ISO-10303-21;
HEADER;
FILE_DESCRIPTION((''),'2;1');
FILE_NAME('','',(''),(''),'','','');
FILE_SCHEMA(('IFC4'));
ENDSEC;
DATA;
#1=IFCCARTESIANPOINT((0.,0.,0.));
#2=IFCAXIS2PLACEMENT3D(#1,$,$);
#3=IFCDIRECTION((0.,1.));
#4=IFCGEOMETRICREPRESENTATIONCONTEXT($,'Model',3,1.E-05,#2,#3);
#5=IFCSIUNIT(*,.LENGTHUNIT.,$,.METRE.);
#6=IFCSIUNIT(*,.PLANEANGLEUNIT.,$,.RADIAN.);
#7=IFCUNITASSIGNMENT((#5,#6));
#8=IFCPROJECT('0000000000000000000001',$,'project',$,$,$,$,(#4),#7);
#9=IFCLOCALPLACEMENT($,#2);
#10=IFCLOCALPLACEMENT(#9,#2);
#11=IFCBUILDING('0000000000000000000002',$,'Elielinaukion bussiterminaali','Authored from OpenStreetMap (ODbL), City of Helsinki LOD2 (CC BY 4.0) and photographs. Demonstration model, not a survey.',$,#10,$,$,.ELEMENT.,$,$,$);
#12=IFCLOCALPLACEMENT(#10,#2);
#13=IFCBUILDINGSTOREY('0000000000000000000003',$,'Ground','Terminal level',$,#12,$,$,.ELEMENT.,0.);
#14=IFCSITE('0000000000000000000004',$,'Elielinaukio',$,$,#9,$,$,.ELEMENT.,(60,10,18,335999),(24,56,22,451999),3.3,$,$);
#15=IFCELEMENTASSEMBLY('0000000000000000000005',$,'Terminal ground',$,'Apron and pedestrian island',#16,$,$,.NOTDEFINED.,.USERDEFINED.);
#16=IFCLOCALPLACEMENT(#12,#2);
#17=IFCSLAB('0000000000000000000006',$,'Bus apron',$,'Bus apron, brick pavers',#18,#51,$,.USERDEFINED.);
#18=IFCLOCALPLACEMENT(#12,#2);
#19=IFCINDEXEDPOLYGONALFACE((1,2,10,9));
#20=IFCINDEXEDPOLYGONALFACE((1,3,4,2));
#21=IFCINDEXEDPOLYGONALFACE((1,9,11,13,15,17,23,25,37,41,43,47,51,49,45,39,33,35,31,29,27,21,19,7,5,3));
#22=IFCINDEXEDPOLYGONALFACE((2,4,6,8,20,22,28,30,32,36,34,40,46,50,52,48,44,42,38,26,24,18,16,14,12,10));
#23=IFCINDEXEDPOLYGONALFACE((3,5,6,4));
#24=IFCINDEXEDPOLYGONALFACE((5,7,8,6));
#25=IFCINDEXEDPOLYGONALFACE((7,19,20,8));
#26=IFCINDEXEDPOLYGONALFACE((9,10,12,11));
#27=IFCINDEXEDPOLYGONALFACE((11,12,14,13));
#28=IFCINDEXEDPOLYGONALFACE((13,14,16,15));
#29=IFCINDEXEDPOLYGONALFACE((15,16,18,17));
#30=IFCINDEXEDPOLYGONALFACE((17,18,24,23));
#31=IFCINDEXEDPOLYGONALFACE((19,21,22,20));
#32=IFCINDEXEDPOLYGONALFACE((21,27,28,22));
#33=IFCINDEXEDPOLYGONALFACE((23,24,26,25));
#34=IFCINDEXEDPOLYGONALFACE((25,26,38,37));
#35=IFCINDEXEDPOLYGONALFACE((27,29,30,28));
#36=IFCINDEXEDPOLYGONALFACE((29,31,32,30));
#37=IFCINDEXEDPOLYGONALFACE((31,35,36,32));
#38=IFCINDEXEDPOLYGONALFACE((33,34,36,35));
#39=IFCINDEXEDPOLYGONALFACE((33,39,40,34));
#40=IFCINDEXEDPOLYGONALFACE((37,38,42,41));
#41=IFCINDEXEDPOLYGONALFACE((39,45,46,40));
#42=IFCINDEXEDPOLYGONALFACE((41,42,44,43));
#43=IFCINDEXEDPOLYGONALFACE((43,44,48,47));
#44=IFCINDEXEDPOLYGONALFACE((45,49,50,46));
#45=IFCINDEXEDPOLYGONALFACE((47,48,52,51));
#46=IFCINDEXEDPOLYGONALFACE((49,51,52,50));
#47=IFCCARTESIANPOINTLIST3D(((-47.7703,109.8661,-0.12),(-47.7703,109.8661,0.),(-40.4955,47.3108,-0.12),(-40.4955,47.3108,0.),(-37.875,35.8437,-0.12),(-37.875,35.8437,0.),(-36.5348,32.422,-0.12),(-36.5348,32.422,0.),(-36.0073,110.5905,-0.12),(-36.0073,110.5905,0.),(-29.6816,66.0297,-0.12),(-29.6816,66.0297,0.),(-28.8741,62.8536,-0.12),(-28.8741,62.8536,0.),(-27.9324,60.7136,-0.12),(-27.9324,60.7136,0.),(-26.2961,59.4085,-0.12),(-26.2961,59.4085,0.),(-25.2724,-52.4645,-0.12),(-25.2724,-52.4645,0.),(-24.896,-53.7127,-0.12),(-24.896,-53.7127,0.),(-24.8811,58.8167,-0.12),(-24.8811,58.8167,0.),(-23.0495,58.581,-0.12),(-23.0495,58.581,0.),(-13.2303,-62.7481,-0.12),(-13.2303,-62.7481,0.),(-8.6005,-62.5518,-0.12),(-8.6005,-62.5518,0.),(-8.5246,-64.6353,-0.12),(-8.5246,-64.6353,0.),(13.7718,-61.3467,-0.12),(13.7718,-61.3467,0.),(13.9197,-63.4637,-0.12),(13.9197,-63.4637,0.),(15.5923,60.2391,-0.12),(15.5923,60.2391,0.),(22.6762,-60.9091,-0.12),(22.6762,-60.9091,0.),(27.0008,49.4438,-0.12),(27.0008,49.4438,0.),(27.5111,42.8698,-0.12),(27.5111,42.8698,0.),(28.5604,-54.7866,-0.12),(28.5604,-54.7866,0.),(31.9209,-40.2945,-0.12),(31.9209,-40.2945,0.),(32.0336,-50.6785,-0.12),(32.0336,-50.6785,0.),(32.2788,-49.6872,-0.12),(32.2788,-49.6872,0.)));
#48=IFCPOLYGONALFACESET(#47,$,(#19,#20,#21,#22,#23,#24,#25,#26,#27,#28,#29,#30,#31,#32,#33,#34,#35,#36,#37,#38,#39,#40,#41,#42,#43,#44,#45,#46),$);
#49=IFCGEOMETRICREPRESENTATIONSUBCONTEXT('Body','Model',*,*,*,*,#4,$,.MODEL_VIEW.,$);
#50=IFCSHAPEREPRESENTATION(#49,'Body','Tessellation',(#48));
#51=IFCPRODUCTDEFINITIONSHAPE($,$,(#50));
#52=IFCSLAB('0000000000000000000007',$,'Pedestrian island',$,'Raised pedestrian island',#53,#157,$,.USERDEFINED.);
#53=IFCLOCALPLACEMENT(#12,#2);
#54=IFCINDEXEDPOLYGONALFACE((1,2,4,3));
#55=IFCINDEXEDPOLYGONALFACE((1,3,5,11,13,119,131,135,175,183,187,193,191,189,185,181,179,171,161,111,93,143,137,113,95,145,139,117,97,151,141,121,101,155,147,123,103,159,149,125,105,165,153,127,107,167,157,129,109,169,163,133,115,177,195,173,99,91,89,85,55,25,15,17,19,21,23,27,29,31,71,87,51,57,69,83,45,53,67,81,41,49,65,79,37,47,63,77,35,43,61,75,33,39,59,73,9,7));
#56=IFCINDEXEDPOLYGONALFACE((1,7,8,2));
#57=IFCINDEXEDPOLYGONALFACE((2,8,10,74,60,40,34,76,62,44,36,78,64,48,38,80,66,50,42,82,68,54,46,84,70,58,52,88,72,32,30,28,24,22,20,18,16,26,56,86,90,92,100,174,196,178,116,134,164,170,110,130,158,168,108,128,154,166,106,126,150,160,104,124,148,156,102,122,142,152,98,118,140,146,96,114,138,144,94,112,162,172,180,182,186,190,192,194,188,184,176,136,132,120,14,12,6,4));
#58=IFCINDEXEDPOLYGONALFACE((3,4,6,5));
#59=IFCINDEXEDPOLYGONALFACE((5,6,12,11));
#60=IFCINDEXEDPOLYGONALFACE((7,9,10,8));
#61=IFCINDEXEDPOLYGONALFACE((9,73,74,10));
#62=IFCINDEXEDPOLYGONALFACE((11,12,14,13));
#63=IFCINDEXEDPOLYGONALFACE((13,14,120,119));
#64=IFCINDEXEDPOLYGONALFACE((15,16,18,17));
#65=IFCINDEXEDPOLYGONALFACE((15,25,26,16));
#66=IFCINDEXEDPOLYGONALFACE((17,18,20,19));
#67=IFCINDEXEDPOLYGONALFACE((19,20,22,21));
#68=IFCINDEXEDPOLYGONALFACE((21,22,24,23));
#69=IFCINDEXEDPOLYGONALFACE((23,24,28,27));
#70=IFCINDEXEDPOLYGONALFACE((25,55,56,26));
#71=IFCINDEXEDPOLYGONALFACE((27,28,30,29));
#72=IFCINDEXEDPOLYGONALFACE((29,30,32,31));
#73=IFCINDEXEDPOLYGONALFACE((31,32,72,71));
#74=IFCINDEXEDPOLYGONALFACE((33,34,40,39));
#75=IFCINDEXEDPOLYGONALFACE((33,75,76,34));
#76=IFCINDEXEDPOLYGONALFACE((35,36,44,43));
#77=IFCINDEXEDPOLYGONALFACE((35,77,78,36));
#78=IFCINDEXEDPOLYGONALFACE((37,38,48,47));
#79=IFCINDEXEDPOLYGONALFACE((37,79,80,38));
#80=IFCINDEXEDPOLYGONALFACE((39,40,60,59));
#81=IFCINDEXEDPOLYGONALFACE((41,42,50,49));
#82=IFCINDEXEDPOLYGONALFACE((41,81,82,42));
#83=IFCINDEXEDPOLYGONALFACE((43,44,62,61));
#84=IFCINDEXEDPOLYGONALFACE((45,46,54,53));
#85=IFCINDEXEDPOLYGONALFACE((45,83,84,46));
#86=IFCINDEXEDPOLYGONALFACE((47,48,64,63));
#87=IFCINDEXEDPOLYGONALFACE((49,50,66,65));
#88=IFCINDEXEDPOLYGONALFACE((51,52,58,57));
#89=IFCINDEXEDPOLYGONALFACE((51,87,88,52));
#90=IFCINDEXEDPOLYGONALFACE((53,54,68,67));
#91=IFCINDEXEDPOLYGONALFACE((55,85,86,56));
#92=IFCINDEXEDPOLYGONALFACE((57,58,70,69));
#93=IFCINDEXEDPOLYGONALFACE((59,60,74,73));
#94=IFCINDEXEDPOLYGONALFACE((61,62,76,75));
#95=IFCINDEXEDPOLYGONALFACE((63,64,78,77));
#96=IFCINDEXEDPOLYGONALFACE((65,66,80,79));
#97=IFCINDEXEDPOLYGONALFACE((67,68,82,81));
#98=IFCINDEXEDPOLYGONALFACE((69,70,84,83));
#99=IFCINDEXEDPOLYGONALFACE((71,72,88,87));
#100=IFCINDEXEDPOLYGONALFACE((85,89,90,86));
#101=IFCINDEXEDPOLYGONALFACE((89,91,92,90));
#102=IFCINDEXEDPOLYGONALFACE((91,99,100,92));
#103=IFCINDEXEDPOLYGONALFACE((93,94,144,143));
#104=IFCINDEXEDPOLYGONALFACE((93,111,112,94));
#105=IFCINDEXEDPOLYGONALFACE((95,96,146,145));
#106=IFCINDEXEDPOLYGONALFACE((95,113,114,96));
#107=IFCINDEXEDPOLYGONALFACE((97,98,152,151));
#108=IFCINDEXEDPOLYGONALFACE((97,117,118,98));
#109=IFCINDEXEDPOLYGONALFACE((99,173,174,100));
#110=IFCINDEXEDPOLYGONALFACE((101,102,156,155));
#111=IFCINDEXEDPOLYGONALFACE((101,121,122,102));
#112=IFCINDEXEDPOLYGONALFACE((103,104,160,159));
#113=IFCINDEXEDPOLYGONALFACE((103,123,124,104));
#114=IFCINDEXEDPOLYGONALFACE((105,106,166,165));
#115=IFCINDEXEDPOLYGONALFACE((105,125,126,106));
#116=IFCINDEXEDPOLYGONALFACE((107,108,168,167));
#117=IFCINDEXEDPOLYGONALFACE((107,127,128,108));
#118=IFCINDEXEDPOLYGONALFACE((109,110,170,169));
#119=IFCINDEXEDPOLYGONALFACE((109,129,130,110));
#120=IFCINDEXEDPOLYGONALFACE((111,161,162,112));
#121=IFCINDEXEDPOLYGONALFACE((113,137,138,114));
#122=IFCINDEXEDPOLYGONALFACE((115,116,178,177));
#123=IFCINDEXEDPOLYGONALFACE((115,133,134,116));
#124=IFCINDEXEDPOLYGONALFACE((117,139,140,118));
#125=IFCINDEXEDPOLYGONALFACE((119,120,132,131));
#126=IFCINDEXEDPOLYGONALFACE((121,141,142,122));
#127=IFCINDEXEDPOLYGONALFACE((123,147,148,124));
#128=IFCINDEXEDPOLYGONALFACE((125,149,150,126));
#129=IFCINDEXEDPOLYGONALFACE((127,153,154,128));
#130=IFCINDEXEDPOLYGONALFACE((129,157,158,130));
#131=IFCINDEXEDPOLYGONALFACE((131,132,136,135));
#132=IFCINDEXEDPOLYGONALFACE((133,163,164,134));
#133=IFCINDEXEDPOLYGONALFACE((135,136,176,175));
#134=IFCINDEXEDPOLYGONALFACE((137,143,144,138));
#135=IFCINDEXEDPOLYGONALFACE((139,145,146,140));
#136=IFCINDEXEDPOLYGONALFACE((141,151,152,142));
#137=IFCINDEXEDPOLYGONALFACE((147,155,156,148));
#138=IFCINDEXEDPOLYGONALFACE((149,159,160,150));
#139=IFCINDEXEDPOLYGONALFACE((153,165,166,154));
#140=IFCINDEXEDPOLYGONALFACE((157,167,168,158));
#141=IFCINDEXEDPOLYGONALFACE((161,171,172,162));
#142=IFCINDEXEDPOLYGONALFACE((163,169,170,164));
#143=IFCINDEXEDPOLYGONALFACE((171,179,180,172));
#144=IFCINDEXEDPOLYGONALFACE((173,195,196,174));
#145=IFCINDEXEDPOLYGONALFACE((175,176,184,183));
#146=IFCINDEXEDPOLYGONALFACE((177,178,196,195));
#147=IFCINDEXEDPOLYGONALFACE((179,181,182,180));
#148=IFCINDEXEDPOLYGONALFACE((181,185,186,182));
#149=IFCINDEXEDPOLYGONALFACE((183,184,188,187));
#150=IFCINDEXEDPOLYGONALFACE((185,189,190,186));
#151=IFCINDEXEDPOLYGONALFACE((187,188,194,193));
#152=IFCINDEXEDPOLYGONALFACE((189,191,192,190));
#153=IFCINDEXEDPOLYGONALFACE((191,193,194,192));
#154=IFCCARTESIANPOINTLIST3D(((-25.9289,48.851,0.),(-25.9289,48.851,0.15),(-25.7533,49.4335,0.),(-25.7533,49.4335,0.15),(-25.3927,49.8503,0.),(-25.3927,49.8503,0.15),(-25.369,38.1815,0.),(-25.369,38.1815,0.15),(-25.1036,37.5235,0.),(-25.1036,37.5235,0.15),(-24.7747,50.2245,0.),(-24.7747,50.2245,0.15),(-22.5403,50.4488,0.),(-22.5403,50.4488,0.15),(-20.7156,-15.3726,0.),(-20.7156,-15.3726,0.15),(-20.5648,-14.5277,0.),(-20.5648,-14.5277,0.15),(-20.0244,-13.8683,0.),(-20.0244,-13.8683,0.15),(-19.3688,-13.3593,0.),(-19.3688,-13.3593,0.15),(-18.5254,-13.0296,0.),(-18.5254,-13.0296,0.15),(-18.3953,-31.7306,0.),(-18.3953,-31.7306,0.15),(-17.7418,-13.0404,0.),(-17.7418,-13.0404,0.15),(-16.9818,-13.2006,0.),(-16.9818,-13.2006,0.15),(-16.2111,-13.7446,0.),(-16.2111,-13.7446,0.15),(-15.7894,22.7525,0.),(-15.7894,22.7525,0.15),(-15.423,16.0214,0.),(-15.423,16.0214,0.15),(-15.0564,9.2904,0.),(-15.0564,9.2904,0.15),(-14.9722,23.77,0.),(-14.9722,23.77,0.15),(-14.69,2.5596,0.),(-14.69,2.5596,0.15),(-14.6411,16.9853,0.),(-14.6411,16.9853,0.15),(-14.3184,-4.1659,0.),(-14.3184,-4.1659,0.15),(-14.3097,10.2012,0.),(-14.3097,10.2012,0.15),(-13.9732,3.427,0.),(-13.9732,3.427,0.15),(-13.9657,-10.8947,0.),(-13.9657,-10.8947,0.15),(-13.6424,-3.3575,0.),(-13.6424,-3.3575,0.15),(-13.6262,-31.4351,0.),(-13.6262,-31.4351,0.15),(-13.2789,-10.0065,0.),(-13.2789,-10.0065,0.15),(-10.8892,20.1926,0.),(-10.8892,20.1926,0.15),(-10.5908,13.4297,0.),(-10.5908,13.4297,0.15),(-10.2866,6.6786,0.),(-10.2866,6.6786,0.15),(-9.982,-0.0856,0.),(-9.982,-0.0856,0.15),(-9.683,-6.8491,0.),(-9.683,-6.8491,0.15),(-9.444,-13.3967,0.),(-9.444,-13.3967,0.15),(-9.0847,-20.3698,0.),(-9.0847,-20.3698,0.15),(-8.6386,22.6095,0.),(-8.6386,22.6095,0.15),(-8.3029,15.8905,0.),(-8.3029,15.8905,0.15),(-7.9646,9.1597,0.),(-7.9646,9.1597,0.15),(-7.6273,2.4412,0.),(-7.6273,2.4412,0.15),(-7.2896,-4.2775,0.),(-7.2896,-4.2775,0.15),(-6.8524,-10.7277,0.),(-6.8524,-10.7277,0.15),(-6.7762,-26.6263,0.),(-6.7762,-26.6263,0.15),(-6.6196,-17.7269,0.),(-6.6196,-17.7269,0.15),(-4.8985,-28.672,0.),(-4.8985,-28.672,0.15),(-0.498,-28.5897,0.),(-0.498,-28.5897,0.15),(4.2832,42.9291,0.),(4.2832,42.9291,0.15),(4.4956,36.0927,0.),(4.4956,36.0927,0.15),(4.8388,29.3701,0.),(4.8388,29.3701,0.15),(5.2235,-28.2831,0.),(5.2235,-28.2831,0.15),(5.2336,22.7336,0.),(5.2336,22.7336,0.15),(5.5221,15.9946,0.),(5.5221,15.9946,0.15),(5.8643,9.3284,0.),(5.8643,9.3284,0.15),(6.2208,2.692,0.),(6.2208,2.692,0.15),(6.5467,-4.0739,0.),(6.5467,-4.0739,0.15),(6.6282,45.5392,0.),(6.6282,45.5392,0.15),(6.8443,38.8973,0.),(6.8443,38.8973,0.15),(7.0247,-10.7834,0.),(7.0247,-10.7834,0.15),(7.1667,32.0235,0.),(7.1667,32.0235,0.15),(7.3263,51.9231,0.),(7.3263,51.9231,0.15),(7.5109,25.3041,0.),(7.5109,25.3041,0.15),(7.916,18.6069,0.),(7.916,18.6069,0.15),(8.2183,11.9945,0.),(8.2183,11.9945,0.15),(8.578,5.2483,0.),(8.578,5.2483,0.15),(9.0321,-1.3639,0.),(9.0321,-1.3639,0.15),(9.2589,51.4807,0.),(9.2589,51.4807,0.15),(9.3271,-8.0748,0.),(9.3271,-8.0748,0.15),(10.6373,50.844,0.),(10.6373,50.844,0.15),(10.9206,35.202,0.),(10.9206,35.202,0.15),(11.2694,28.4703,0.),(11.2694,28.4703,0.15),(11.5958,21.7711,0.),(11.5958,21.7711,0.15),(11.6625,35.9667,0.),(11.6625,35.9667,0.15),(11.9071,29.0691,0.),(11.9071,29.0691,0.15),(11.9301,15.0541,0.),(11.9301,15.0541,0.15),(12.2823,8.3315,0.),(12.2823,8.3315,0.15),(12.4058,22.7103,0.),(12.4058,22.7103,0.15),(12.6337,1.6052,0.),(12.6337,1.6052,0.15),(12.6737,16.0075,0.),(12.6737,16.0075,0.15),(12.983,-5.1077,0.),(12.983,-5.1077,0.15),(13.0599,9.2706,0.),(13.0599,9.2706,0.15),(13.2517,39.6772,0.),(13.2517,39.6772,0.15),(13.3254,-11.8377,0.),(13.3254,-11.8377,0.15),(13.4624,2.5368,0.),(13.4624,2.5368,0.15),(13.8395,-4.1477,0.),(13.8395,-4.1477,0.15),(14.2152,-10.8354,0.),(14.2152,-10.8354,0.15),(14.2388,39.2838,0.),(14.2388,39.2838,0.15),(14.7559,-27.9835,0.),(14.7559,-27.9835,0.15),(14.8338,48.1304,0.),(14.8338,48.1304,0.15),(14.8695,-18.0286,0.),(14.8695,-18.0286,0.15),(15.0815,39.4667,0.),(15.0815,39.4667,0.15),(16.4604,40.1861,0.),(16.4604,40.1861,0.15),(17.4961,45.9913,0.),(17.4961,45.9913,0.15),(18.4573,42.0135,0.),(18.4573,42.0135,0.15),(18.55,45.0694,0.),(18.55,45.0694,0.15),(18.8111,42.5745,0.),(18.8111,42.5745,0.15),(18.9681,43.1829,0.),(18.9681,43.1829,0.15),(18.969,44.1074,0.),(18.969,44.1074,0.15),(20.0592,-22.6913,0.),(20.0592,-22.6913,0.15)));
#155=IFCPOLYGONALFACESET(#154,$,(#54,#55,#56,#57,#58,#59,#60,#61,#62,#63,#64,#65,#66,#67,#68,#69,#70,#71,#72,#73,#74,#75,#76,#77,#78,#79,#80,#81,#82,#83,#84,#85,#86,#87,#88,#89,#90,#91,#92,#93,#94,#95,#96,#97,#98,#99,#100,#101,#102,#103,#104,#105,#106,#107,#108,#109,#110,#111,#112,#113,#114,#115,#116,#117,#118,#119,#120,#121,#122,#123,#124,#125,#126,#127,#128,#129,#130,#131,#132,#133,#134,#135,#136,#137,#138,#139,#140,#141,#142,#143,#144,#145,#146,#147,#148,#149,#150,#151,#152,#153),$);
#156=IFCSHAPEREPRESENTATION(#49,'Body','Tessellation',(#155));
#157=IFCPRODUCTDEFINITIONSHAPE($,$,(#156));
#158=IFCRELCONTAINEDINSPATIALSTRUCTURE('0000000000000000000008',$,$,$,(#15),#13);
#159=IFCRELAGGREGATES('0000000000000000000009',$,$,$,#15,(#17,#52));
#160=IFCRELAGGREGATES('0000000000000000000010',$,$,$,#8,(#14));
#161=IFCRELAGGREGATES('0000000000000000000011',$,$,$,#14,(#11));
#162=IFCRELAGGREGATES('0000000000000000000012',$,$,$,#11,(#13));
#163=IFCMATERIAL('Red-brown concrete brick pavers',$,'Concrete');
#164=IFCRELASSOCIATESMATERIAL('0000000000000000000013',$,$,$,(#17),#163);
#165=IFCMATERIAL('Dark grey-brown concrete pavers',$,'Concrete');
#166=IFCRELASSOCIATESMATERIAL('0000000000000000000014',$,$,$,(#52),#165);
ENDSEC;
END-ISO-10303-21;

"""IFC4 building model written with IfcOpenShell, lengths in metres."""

from ifc_helpers import new_model, si_unit, direction, frame, origin, place, context, subcontext, project, spatial, polyline, outline, extrude, material, element, aggregate, save


model = new_model("IFC4")

# Units and contexts
model_context = context("Model", 3, precision=1e-05, world=origin(), true_north=direction((0.0, 1.0)))
body_context = subcontext(model_context, "Body", "Model", "MODEL_VIEW")
ifc_project = project(units=[si_unit("LENGTHUNIT", "METRE"), si_unit("PLANEANGLEUNIT", "RADIAN")], contexts=[model_context])

# Site, building, storey
site_placement = place(None, origin())
site = spatial("IfcSite", under=ifc_project, at=site_placement, Name="Elielinaukio", CompositionType="ELEMENT", RefLatitude=(60, 10, 18, 335999), RefLongitude=(24, 56, 22, 451999), RefElevation=3.3)
building_placement = place(site_placement, origin())
building = spatial("IfcBuilding", under=site, at=building_placement, Name="Elielinaukion bussiterminaali", Description="Authored from OpenStreetMap (ODbL), City of Helsinki LOD2 (CC BY 4.0) and photographs. Demonstration model, not a survey.", CompositionType="ELEMENT")
storey_placement = place(building_placement, origin())
storey = spatial("IfcBuildingStorey", under=building, at=storey_placement, Name="Ground", Description="Terminal level", CompositionType="ELEMENT", Elevation=0.0)

# Element assembly, slabs
assembly_1_placement = place(building_placement, origin())
assembly_1 = element("IfcElementAssembly", 1, at=assembly_1_placement, inside=storey, Name="Terminal ground", ObjectType="Apron and pedestrian island", AssemblyPlace="NOTDEFINED", PredefinedType="USERDEFINED")
ifc_material_1 = material(Name="Red-brown concrete brick pavers", Category="Concrete")
slab_1_placement = place(building_placement, origin())
slab_1 = element("IfcSlab", 2, at=slab_1_placement, material=ifc_material_1, Name="Bus apron", ObjectType="Bus apron, brick pavers", PredefinedType="USERDEFINED", context=body_context, shape_type="SweptSolid", body=[
    extrude(outline(polyline([(-37.875, 35.8437), (-40.4955, 47.3108), (-47.7703, 109.8661), (-36.0073, 110.5905), (-29.6816, 66.0297), (-28.8741, 62.8536), (-27.9324, 60.7136), (-26.2961, 59.4085), (-24.8811, 58.8167), (-23.0495, 58.581), (15.5923, 60.2391), (27.0008, 49.4438), (27.5111, 42.8698), (31.9209, -40.2945), (32.2788, -49.6872), (32.0336, -50.6785), (28.5604, -54.7866), (22.6762, -60.9091), (13.7718, -61.3467), (13.9197, -63.4637), (-8.5246, -64.6353), (-8.6005, -62.5518), (-13.2303, -62.7481), (-24.896, -53.7127), (-25.2724, -52.4645), (-36.5348, 32.422), (-37.875, 35.8437)])), frame((0.0, 0.0, -0.12)), (0.0, 0.0, 1.0), 0.12),
])
ifc_material_2 = material(Name="Dark grey-brown concrete pavers", Category="Concrete")
slab_2_placement = place(building_placement, origin())
slab_2 = element("IfcSlab", 3, at=slab_2_placement, material=ifc_material_2, Name="Pedestrian island", ObjectType="Raised pedestrian island", PredefinedType="USERDEFINED", context=body_context, shape_type="SweptSolid", body=[
    extrude(outline(polyline([(-18.3953, -31.7306), (-20.7156, -15.3726), (-20.5648, -14.5277), (-20.0244, -13.8683), (-19.3688, -13.3593), (-18.5254, -13.0296), (-17.7418, -13.0404), (-16.9818, -13.2006), (-16.2111, -13.7446), (-9.0847, -20.3698), (-6.6196, -17.7269), (-13.9657, -10.8947), (-13.2789, -10.0065), (-9.444, -13.3967), (-6.8524, -10.7277), (-14.3184, -4.1659), (-13.6424, -3.3575), (-9.683, -6.8491), (-7.2896, -4.2775), (-14.69, 2.5596), (-13.9732, 3.427), (-9.982, -0.0856), (-7.6273, 2.4412), (-15.0564, 9.2904), (-14.3097, 10.2012), (-10.2866, 6.6786), (-7.9646, 9.1597), (-15.423, 16.0214), (-14.6411, 16.9853), (-10.5908, 13.4297), (-8.3029, 15.8905), (-15.7894, 22.7525), (-14.9722, 23.77), (-10.8892, 20.1926), (-8.6386, 22.6095), (-25.1036, 37.5235), (-25.369, 38.1815), (-25.9289, 48.851), (-25.7533, 49.4335), (-25.3927, 49.8503), (-24.7747, 50.2245), (-22.5403, 50.4488), (7.3263, 51.9231), (9.2589, 51.4807), (10.6373, 50.844), (14.8338, 48.1304), (17.4961, 45.9913), (18.55, 45.0694), (18.969, 44.1074), (18.9681, 43.1829), (18.8111, 42.5745), (18.4573, 42.0135), (16.4604, 40.1861), (15.0815, 39.4667), (14.2388, 39.2838), (13.2517, 39.6772), (6.6282, 45.5392), (4.2832, 42.9291), (11.6625, 35.9667), (10.9206, 35.202), (6.8443, 38.8973), (4.4956, 36.0927), (11.9071, 29.0691), (11.2694, 28.4703), (7.1667, 32.0235), (4.8388, 29.3701), (12.4058, 22.7103), (11.5958, 21.7711), (7.5109, 25.3041), (5.2336, 22.7336), (12.6737, 16.0075), (11.9301, 15.0541), (7.916, 18.6069), (5.5221, 15.9946), (13.0599, 9.2706), (12.2823, 8.3315), (8.2183, 11.9945), (5.8643, 9.3284), (13.4624, 2.5368), (12.6337, 1.6052), (8.578, 5.2483), (6.2208, 2.692), (13.8395, -4.1477), (12.983, -5.1077), (9.0321, -1.3639), (6.5467, -4.0739), (14.2152, -10.8354), (13.3254, -11.8377), (9.3271, -8.0748), (7.0247, -10.7834), (14.8695, -18.0286), (20.0592, -22.6913), (14.7559, -27.9835), (5.2235, -28.2831), (-0.498, -28.5897), (-4.8985, -28.672), (-6.7762, -26.6263), (-13.6262, -31.4351), (-18.3953, -31.7306)])), origin(), (0.0, 0.0, 1.0), 0.15),
])

aggregate(assembly_1, [slab_1, slab_2])

save(model, "model.ifc")
